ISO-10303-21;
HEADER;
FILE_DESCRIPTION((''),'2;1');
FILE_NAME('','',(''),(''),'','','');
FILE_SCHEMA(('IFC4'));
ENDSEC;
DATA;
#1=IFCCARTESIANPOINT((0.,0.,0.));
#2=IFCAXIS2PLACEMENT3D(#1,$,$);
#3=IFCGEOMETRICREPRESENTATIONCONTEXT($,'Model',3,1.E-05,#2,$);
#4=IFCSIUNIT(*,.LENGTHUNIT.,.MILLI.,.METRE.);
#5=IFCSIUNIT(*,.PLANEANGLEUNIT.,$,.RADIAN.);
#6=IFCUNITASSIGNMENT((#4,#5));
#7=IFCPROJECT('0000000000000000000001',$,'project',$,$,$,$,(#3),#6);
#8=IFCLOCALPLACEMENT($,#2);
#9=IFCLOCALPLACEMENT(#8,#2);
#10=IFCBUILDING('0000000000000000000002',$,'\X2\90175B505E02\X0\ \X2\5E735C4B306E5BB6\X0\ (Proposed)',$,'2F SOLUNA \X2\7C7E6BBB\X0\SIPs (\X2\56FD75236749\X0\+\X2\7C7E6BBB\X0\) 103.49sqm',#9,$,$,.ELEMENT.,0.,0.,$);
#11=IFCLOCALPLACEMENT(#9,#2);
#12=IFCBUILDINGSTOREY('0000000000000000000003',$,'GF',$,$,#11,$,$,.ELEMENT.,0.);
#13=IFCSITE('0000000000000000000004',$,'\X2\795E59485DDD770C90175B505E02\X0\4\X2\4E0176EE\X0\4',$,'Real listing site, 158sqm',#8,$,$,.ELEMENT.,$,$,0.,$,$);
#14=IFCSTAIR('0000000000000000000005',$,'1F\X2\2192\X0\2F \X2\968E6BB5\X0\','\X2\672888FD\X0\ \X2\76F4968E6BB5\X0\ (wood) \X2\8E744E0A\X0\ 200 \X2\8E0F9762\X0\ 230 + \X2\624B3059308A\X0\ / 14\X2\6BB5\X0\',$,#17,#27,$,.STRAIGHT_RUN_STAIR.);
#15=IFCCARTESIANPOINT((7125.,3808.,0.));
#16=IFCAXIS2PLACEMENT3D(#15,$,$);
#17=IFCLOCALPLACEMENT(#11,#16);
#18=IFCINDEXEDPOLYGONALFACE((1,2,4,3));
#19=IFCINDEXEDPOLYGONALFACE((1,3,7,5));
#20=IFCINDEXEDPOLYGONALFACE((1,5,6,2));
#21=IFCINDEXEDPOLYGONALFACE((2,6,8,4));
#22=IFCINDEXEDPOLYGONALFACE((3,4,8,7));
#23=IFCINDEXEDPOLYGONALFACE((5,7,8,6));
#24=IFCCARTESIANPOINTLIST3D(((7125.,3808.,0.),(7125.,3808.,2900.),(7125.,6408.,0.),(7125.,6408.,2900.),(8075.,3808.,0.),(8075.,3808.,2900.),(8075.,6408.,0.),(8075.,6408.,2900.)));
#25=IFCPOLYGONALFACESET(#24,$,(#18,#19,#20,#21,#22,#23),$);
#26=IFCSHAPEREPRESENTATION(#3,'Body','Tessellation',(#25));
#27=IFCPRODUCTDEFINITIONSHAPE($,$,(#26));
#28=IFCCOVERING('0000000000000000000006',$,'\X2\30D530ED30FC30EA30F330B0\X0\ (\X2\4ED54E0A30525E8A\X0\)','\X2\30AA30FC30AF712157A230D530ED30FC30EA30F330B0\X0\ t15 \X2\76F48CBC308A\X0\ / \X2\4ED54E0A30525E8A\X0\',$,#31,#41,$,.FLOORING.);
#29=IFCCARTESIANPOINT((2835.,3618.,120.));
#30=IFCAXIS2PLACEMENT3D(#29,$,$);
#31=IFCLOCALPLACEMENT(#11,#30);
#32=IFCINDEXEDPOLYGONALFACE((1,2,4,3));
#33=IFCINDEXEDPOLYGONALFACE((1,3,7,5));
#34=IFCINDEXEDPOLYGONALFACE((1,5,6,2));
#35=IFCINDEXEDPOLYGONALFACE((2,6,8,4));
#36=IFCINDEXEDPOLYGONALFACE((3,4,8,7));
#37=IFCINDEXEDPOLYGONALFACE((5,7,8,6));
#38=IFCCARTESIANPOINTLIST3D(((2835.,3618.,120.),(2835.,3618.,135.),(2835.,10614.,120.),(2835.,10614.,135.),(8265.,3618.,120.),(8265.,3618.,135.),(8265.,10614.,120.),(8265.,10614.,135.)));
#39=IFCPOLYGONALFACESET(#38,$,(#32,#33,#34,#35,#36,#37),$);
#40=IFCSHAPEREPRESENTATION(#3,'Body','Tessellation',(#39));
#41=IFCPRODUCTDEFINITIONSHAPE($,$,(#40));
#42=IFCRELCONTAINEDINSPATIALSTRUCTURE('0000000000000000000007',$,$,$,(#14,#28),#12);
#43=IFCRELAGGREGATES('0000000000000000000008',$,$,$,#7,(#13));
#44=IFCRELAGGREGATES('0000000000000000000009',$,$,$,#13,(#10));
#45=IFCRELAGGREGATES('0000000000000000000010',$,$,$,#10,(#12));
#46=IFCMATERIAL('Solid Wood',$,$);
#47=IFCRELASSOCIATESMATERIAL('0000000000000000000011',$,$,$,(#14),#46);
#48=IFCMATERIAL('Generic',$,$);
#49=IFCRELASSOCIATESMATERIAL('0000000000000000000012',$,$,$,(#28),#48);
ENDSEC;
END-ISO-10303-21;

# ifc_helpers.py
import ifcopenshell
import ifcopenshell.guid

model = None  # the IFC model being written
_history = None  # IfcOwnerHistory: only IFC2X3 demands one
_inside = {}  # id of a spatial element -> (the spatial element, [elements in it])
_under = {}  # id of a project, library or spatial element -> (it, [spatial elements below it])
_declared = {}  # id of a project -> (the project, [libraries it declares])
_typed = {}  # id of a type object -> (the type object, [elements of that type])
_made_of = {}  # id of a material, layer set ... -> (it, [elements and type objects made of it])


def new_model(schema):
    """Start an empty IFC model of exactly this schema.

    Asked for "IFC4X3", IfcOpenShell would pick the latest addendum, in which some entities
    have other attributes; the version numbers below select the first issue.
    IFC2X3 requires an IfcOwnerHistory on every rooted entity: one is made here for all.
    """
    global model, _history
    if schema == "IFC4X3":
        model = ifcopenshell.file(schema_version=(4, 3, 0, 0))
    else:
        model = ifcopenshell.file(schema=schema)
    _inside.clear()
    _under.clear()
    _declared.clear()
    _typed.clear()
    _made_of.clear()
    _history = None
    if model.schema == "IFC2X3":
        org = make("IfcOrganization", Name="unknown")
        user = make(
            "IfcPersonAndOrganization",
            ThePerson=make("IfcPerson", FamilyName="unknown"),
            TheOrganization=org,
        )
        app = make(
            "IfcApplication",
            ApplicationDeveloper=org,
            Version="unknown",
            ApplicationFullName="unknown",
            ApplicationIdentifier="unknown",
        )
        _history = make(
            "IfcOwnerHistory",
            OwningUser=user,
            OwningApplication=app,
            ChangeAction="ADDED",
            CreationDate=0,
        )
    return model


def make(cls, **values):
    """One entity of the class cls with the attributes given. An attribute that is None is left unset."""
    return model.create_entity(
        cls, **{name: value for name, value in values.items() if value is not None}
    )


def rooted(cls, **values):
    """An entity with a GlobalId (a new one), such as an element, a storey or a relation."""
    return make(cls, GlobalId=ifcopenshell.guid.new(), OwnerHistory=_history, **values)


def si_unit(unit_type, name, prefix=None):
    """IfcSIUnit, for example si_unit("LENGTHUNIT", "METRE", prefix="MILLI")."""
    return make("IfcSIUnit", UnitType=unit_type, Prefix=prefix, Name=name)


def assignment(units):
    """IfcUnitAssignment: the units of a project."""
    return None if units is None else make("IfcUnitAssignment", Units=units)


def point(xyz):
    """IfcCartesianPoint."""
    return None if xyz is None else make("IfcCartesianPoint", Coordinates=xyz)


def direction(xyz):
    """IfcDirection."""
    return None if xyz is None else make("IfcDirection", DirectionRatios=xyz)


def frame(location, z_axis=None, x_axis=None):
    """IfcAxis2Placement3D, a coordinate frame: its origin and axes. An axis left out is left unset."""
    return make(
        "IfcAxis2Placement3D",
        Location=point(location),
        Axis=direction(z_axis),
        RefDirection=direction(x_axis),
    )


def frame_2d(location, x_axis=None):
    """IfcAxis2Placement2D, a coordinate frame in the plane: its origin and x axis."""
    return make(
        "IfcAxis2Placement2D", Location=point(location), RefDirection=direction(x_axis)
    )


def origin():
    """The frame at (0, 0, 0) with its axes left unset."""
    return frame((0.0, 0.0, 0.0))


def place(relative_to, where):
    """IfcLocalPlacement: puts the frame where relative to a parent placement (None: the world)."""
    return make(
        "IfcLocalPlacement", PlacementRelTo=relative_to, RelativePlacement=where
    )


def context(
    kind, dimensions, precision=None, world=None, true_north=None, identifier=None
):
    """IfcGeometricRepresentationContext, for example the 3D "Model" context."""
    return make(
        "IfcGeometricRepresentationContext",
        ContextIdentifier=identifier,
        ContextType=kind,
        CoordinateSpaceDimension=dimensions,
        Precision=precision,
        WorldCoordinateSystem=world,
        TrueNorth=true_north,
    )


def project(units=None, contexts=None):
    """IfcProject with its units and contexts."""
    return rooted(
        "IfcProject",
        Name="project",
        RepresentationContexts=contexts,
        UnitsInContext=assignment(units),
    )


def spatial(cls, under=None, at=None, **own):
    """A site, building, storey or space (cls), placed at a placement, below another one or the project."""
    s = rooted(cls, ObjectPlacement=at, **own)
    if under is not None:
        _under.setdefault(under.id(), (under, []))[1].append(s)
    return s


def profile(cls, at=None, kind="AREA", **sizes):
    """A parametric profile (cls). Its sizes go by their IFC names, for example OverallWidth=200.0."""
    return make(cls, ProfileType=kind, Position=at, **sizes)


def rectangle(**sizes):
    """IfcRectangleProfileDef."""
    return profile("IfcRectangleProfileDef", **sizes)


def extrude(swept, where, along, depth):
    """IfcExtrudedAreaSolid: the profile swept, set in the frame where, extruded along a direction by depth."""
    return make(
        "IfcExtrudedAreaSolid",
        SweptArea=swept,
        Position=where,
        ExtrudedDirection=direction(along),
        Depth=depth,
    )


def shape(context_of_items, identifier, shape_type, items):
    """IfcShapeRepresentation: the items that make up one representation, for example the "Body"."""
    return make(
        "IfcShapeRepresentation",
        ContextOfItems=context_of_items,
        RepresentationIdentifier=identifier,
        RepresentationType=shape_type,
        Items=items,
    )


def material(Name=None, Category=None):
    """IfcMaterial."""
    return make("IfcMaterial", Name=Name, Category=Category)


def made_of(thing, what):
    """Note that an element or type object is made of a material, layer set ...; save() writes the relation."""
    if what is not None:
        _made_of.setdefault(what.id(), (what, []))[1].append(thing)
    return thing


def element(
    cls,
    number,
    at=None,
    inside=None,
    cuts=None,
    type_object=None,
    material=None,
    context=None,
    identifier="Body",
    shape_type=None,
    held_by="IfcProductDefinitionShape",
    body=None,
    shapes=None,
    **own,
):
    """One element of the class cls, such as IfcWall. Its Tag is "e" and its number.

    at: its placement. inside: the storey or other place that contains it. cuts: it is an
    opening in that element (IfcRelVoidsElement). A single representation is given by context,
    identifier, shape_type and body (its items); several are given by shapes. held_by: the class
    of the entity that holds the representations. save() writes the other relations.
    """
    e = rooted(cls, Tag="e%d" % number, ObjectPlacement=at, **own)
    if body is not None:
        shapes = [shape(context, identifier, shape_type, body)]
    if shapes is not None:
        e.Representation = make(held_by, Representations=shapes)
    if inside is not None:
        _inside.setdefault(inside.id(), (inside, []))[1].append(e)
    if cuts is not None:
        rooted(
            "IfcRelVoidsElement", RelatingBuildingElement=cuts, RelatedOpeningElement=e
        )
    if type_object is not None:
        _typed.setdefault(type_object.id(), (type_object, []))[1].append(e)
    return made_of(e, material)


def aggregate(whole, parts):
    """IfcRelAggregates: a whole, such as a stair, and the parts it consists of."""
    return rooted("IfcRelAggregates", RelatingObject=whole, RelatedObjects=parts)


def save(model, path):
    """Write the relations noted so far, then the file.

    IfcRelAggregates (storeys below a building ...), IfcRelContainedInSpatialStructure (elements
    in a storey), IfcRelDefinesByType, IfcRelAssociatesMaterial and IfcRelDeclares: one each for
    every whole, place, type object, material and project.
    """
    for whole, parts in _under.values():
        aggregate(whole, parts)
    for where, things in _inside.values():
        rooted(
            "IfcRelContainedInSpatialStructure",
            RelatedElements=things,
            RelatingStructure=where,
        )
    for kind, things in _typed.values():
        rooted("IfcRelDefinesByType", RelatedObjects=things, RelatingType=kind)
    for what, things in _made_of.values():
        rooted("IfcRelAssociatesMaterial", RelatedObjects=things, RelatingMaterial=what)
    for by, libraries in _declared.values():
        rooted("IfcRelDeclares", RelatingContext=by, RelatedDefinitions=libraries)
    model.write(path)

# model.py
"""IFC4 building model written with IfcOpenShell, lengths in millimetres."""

from ifc_helpers import new_model, si_unit, frame, frame_2d, origin, place, context, project, spatial, rectangle, extrude, material, element, save


model = new_model("IFC4")

# Units and contexts
model_context = context("Model", 3, precision=1e-05, world=origin())
ifc_project = project(units=[si_unit("LENGTHUNIT", "METRE", prefix="MILLI"), si_unit("PLANEANGLEUNIT", "RADIAN")], contexts=[model_context])

# Site, building, storey
site_placement = place(None, origin())
site = spatial("IfcSite", under=ifc_project, at=site_placement, Name="神奈川県逗子市4丁目4", ObjectType="Real listing site, 158sqm", CompositionType="ELEMENT", RefElevation=0.0)
building_placement = place(site_placement, origin())
building = spatial("IfcBuilding", under=site, at=building_placement, Name="逗子市 平屋の家 (Proposed)", ObjectType="2F SOLUNA 籾殻SIPs (国産杉+籾殻) 103.49sqm", CompositionType="ELEMENT", ElevationOfRefHeight=0.0, ElevationOfTerrain=0.0)
storey_placement = place(building_placement, origin())
storey = spatial("IfcBuildingStorey", under=building, at=storey_placement, Name="GF", CompositionType="ELEMENT", Elevation=0.0)

# Shared definitions
ifc_material_1 = material(Name="Solid Wood")
ifc_material_2 = material(Name="Generic")

# Stair
stair_placement = place(storey_placement, frame((7125.0, 3808.0, 0.0)))
element("IfcStair", 1, at=stair_placement, inside=storey, material=ifc_material_1, Name="1F→2F 階段", Description="木製 直階段 (wood) 蹴上 200 踏面 230 + 手すり / 14段", PredefinedType="STRAIGHT_RUN_STAIR", context=model_context, shape_type="SweptSolid", body=[
    extrude(rectangle(XDim=950.0, YDim=2600.0, at=frame_2d((475.0, 1300.0))), frame((7125.0, 3808.0, 0.0)), (0.0, 0.0, 1.0), 2900.0),
])

# Covering
covering_placement = place(storey_placement, frame((2835.0, 3618.0, 120.0)))
element("IfcCovering", 2, at=covering_placement, inside=storey, material=ifc_material_2, Name="フローリング (仕上げ床)", Description="オーク無垢フローリング t15 直貼り / 仕上げ床", PredefinedType="FLOORING", context=model_context, shape_type="SweptSolid", body=[
    extrude(rectangle(XDim=5430.0, YDim=6996.0, at=frame_2d((2715.0, 3498.0))), frame((2835.0, 3618.0, 120.0)), (0.0, 0.0, 1.0), 15.0),
])

save(model, "model.ifc")
